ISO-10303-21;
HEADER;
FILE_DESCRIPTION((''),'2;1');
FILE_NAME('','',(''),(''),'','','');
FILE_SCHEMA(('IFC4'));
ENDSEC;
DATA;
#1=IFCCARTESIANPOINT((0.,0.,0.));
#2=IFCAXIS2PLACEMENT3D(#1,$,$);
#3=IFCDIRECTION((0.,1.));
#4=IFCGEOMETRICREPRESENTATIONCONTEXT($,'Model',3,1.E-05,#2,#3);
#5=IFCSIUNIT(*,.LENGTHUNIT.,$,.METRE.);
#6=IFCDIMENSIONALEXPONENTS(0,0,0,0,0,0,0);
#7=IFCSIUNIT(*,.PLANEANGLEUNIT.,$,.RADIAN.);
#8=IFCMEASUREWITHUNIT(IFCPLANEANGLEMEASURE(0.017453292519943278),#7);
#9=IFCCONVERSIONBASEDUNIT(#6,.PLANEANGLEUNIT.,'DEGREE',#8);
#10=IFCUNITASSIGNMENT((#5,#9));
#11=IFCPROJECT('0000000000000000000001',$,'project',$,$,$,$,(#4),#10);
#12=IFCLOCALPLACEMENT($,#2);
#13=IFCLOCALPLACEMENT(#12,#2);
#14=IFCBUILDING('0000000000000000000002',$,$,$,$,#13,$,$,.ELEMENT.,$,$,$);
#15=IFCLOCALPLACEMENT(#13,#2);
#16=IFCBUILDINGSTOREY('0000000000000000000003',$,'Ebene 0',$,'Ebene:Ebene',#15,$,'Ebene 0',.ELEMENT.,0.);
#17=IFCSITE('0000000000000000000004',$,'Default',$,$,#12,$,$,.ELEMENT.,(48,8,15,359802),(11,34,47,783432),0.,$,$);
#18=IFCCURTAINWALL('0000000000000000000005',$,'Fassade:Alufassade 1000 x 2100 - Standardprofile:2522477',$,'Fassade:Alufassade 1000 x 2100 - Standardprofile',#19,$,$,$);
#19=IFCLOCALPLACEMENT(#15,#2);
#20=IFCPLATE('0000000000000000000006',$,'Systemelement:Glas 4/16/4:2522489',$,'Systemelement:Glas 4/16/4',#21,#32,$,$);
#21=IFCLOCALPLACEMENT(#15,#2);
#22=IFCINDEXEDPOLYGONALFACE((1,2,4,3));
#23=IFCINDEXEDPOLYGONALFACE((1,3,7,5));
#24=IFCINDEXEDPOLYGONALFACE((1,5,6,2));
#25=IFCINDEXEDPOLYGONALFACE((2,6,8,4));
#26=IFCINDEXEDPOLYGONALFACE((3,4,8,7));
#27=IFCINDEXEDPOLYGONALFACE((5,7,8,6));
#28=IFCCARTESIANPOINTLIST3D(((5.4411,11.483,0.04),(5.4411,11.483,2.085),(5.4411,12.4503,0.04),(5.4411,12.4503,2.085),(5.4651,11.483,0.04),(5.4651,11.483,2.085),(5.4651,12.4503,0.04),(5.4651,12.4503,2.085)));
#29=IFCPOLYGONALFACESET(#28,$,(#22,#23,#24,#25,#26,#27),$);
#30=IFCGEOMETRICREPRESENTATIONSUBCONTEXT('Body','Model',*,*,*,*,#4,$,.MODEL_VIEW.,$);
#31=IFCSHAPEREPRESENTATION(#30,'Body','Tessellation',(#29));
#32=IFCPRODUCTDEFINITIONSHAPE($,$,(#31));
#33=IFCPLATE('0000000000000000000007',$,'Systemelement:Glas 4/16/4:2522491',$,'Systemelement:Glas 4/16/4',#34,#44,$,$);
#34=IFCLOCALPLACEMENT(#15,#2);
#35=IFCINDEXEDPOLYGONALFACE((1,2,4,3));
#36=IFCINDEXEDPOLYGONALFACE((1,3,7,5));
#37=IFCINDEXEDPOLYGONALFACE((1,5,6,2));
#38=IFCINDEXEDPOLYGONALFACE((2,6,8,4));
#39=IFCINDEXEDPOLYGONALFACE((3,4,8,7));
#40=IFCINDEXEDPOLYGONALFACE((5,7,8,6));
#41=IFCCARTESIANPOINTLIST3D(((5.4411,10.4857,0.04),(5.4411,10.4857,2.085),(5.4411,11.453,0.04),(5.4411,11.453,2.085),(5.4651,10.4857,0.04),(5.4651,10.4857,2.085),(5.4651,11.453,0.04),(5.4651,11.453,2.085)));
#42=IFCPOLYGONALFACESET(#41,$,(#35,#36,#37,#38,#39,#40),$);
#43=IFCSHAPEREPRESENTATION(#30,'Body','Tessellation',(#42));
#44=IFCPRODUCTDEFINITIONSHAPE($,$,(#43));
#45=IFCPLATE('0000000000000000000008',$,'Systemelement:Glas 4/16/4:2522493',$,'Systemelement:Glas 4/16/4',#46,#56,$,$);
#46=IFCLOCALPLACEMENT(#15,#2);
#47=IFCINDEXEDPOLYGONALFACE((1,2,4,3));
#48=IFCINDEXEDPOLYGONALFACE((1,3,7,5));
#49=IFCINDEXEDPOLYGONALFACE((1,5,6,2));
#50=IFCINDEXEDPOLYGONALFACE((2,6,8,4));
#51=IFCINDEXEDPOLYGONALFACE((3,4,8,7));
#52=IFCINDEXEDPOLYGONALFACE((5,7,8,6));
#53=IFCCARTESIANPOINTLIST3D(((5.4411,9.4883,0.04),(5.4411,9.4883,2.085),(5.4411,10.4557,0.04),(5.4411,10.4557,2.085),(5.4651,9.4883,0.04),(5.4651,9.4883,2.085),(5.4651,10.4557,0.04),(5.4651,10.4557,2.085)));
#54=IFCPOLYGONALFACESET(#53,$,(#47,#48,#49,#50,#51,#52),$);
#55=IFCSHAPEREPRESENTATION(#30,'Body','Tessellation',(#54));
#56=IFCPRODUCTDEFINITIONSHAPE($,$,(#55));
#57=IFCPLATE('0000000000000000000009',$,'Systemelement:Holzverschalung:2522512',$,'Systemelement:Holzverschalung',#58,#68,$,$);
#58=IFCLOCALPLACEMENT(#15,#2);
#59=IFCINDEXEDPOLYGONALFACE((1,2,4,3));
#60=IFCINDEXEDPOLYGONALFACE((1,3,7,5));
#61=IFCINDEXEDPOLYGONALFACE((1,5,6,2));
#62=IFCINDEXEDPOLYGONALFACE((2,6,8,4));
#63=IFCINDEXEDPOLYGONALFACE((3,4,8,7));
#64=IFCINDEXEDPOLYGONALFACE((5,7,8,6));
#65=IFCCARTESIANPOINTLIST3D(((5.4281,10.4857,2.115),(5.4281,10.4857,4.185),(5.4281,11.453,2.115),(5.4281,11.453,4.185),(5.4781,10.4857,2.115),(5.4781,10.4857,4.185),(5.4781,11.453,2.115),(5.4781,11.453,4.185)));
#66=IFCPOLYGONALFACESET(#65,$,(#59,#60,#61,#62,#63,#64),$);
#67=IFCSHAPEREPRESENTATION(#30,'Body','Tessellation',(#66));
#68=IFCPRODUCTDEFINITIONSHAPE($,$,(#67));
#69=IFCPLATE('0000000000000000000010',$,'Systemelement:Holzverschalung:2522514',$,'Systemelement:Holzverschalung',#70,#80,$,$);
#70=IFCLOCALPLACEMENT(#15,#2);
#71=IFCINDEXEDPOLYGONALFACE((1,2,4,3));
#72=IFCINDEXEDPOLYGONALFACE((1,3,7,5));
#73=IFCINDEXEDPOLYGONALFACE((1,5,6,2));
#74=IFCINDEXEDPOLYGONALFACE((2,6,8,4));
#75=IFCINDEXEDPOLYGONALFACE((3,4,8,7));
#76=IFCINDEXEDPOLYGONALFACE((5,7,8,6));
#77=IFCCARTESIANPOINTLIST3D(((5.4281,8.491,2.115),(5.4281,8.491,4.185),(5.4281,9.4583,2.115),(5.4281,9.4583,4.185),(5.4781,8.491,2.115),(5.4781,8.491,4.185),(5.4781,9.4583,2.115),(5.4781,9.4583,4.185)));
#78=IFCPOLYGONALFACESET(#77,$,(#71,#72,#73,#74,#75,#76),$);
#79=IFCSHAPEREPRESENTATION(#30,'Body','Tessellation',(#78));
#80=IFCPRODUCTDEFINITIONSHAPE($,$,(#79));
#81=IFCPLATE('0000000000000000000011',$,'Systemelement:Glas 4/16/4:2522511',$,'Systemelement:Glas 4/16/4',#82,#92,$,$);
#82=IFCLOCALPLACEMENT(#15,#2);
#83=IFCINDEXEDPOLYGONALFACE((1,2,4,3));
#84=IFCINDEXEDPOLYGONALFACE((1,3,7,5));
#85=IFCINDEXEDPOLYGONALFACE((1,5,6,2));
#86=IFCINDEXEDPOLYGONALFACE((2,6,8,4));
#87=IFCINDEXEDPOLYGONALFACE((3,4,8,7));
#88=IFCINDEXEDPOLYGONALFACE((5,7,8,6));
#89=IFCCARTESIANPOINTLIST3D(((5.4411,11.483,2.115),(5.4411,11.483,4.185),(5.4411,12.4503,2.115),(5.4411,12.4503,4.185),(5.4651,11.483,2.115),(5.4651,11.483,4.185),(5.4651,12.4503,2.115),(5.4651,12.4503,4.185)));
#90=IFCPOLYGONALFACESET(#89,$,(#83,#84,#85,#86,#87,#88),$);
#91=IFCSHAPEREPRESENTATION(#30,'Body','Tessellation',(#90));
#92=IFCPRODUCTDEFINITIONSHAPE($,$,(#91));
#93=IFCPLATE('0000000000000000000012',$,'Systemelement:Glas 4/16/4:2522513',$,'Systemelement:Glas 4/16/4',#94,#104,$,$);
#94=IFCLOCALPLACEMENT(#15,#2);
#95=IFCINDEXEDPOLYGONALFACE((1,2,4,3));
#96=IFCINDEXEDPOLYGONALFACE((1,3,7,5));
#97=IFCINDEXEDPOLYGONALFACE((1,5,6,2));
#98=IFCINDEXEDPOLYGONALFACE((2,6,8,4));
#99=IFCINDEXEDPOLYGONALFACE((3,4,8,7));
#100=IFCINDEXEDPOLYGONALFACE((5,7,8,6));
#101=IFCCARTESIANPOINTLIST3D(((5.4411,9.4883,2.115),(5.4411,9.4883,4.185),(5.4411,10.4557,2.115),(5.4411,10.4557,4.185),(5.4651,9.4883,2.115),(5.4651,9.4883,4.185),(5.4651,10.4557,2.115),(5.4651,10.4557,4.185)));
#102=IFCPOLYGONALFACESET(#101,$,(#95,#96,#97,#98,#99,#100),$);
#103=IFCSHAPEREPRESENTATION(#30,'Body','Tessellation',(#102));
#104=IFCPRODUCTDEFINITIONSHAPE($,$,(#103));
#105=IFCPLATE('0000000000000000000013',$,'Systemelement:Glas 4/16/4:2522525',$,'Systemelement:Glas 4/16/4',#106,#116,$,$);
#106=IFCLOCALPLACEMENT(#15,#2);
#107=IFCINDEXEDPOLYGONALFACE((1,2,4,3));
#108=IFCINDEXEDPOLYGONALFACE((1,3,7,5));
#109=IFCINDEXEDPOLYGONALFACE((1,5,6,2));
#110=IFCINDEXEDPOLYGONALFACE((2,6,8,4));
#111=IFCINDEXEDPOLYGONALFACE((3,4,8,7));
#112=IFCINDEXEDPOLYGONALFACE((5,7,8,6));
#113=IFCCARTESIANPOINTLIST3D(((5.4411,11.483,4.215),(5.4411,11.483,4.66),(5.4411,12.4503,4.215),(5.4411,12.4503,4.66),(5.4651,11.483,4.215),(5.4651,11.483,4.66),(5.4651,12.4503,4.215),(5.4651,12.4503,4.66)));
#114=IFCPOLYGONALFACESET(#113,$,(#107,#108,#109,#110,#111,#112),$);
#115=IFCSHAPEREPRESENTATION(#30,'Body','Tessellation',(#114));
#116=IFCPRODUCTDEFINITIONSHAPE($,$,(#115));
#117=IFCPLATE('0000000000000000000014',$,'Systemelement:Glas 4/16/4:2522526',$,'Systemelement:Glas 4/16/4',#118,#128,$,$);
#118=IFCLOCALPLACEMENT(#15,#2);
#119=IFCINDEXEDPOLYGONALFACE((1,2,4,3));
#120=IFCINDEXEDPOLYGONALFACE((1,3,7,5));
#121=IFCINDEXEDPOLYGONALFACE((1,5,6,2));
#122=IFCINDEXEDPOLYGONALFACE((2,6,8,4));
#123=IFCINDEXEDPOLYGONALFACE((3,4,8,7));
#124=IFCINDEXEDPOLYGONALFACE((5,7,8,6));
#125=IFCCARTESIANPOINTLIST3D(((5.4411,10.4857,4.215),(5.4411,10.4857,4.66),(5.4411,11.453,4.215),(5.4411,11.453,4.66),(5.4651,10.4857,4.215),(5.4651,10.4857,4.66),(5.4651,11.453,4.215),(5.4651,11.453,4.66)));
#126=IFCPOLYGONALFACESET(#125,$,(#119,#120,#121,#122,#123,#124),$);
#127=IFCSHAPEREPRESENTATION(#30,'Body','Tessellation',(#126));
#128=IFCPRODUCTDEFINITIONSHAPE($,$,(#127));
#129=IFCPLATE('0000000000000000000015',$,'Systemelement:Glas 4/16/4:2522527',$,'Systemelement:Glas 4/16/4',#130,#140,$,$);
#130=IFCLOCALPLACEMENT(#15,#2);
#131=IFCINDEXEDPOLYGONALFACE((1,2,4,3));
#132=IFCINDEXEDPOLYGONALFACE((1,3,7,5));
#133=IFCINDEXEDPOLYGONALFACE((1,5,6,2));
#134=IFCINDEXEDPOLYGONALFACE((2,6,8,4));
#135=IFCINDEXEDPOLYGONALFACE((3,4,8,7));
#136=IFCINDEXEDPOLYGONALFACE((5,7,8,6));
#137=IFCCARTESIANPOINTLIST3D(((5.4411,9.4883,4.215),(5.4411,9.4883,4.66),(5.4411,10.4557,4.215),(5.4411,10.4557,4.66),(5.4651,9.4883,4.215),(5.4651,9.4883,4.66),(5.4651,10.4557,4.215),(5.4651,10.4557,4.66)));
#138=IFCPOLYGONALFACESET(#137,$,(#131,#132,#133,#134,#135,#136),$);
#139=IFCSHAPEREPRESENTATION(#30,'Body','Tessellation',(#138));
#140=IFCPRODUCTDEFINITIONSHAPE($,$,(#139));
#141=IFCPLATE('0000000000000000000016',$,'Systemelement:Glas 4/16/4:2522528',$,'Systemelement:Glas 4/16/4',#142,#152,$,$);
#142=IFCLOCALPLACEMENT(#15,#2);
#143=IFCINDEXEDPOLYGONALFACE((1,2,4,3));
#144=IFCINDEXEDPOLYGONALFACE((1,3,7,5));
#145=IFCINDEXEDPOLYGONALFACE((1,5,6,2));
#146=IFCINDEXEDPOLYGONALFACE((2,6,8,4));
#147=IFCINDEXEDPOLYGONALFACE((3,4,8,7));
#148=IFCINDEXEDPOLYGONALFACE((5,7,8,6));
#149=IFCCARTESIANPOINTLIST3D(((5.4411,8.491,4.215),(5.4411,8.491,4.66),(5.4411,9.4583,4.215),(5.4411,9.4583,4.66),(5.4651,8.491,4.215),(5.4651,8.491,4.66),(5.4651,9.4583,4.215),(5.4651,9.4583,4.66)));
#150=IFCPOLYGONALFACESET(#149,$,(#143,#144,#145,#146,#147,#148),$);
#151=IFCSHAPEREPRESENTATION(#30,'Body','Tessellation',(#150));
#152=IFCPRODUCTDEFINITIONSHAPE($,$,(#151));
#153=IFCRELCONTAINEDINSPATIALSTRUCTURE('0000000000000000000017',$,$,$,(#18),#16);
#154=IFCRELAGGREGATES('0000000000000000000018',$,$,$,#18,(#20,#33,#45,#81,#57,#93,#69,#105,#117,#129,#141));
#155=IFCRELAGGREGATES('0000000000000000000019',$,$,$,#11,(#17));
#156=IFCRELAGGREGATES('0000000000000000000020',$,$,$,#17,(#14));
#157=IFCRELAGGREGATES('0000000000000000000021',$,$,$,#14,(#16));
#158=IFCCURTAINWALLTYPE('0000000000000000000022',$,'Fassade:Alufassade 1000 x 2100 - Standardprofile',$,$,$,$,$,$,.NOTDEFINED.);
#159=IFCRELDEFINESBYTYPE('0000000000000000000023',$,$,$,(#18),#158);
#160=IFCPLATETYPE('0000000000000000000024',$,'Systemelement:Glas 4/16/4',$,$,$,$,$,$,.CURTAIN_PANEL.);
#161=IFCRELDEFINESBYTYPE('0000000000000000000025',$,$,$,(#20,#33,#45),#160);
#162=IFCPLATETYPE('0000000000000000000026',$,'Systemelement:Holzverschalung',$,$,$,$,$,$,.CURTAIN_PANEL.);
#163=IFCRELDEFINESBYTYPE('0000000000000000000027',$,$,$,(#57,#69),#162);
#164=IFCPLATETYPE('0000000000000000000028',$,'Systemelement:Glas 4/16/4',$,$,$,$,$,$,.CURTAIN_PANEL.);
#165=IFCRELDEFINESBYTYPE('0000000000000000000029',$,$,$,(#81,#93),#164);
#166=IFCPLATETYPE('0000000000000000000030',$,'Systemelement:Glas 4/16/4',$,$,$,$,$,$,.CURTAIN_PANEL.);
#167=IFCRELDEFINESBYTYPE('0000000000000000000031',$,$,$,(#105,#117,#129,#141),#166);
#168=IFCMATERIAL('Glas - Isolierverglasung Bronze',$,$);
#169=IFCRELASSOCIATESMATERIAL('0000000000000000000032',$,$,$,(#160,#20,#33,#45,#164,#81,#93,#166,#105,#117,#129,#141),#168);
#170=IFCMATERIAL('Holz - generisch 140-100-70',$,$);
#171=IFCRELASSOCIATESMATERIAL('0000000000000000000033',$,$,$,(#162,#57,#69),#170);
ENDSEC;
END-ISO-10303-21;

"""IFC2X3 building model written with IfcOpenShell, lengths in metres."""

from ifc_helpers import new_model, entity, si_unit, converted_unit, direction, frame, origin, origin_2d_with_axis, place, context, subcontext, project, spatial, rectangle, extrude, source, transform, mapped, material, type_object, type_shapes, element, aggregate, save


model = new_model("IFC2X3")

# Units and contexts
model_context = context("Model", 3, precision=1e-05, world=origin(), true_north=direction((0.0, 1.0)))
body_context = subcontext(model_context, "Body", "Model", "MODEL_VIEW")
ifc_project = project(units=[si_unit("LENGTHUNIT", "METRE"), converted_unit("PLANEANGLEUNIT", "DEGREE", entity("IfcPlaneAngleMeasure", 0.017453292519943278), si_unit("PLANEANGLEUNIT", "RADIAN"), dimensions=[0, 0, 0, 0, 0, 0, 0])], contexts=[model_context])

# Site, building, storey
site_placement = place(None, origin())
site = spatial("IfcSite", under=ifc_project, at=site_placement, Name="Default", CompositionType="ELEMENT", RefLatitude=(48, 8, 15, 359802), RefLongitude=(11, 34, 47, 783432), RefElevation=0.0)
building_placement = place(site_placement, origin())
building = spatial("IfcBuilding", under=site, at=building_placement, CompositionType="ELEMENT")
storey_placement = place(building_placement, origin())
storey = spatial("IfcBuildingStorey", under=building, at=storey_placement, Name="Ebene 0", ObjectType="Ebene:Ebene", LongName="Ebene 0", CompositionType="ELEMENT", Elevation=0.0)

# Curtain wall, plates
curtain_wall_type = type_object("IfcCurtainWallType", Name="Fassade:Alufassade 1000 x 2100 - Standardprofile", PredefinedType="NOTDEFINED")
curtain_wall_placement = place(storey_placement, origin())
curtain_wall = element("IfcCurtainWall", 1, at=curtain_wall_placement, inside=storey, type_object=curtain_wall_type, Name="Fassade:Alufassade 1000 x 2100 - Standardprofile:2522477", ObjectType="Fassade:Alufassade 1000 x 2100 - Standardprofile")
ifc_material_1 = material(Name="Glas - Isolierverglasung Bronze")
plate_type_1 = type_object("IfcPlateType", Name="Systemelement:Glas 4/16/4", PredefinedType="CURTAIN_PANEL", material=ifc_material_1)
shared_shape_1 = source(origin(), body_context, "Body", "SweptSolid", [
    extrude(rectangle(XDim=0.024, YDim=0.9673, at=origin_2d_with_axis()), frame((0.0, 0.0, 0.0), z_axis=(0.0, 0.0, 1.0), x_axis=(0.0, 1.0, 0.0)), (0.0, 0.0, 1.0), 2.045),
])
type_shapes(plate_type_1, [shared_shape_1])
plate_1_placement = place(curtain_wall_placement, frame((5.4531, 11.9666, 0.04), z_axis=(0.0, 0.0, 1.0), x_axis=(0.0, -1.0, 0.0)))
plate_1 = element("IfcPlate", 2, at=plate_1_placement, type_object=plate_type_1, material=ifc_material_1, Name="Systemelement:Glas 4/16/4:2522489", ObjectType="Systemelement:Glas 4/16/4", context=body_context, shape_type="MappedRepresentation", body=[
    mapped(shared_shape_1, transform((0.0, 0.0, 0.0), scale=1.0)),
])
plate_2_placement = place(curtain_wall_placement, frame((5.4531, 10.9693, 0.04), z_axis=(0.0, 0.0, 1.0), x_axis=(0.0, -1.0, 0.0)))
plate_2 = element("IfcPlate", 3, at=plate_2_placement, type_object=plate_type_1, material=ifc_material_1, Name="Systemelement:Glas 4/16/4:2522491", ObjectType="Systemelement:Glas 4/16/4", context=body_context, shape_type="MappedRepresentation", body=[
    mapped(shared_shape_1, transform((0.0, 0.0, 0.0), scale=1.0)),
])
plate_3_placement = place(curtain_wall_placement, frame((5.4531, 9.972, 0.04), z_axis=(0.0, 0.0, 1.0), x_axis=(0.0, -1.0, 0.0)))
plate_3 = element("IfcPlate", 4, at=plate_3_placement, type_object=plate_type_1, material=ifc_material_1, Name="Systemelement:Glas 4/16/4:2522493", ObjectType="Systemelement:Glas 4/16/4", context=body_context, shape_type="MappedRepresentation", body=[
    mapped(shared_shape_1, transform((0.0, 0.0, 0.0), scale=1.0)),
])
ifc_material_2 = material(Name="Holz - generisch 140-100-70")
plate_type_2 = type_object("IfcPlateType", Name="Systemelement:Holzverschalung", PredefinedType="CURTAIN_PANEL", material=ifc_material_2)
shared_shape_2 = source(origin(), body_context, "Body", "SweptSolid", [
    extrude(rectangle(XDim=0.05, YDim=0.9673, at=origin_2d_with_axis()), frame((0.0, 0.0, 0.0), z_axis=(0.0, 0.0, 1.0), x_axis=(0.0, 1.0, 0.0)), (0.0, 0.0, 1.0), 2.07),
])
type_shapes(plate_type_2, [shared_shape_2])
plate_4_placement = place(curtain_wall_placement, frame((5.4531, 10.9693, 2.115), z_axis=(0.0, 0.0, 1.0), x_axis=(0.0, -1.0, 0.0)))
plate_4 = element("IfcPlate", 5, at=plate_4_placement, type_object=plate_type_2, material=ifc_material_2, Name="Systemelement:Holzverschalung:2522512", ObjectType="Systemelement:Holzverschalung", context=body_context, shape_type="MappedRepresentation", body=[
    mapped(shared_shape_2, transform((0.0, 0.0, 0.0), scale=1.0)),
])
plate_5_placement = place(curtain_wall_placement, frame((5.4531, 8.9747, 2.115), z_axis=(0.0, 0.0, 1.0), x_axis=(0.0, -1.0, 0.0)))
plate_5 = element("IfcPlate", 6, at=plate_5_placement, type_object=plate_type_2, material=ifc_material_2, Name="Systemelement:Holzverschalung:2522514", ObjectType="Systemelement:Holzverschalung", context=body_context, shape_type="MappedRepresentation", body=[
    mapped(shared_shape_2, transform((0.0, 0.0, 0.0), scale=1.0)),
])
plate_type_3 = type_object("IfcPlateType", Name="Systemelement:Glas 4/16/4", PredefinedType="CURTAIN_PANEL", material=ifc_material_1)
shared_shape_3 = source(origin(), body_context, "Body", "SweptSolid", [
    extrude(rectangle(XDim=0.024, YDim=0.9673, at=origin_2d_with_axis()), frame((0.0, 0.0, 0.0), z_axis=(0.0, 0.0, 1.0), x_axis=(0.0, 1.0, 0.0)), (0.0, 0.0, 1.0), 2.07),
])
type_shapes(plate_type_3, [shared_shape_3])
plate_6_placement = place(curtain_wall_placement, frame((5.4531, 11.9666, 2.115), z_axis=(0.0, 0.0, 1.0), x_axis=(0.0, -1.0, 0.0)))
plate_6 = element("IfcPlate", 7, at=plate_6_placement, type_object=plate_type_3, material=ifc_material_1, Name="Systemelement:Glas 4/16/4:2522511", ObjectType="Systemelement:Glas 4/16/4", context=body_context, shape_type="MappedRepresentation", body=[
    mapped(shared_shape_3, transform((0.0, 0.0, 0.0), scale=1.0)),
])
plate_7_placement = place(curtain_wall_placement, frame((5.4531, 9.972, 2.115), z_axis=(0.0, 0.0, 1.0), x_axis=(0.0, -1.0, 0.0)))
plate_7 = element("IfcPlate", 8, at=plate_7_placement, type_object=plate_type_3, material=ifc_material_1, Name="Systemelement:Glas 4/16/4:2522513", ObjectType="Systemelement:Glas 4/16/4", context=body_context, shape_type="MappedRepresentation", body=[
    mapped(shared_shape_3, transform((0.0, 0.0, 0.0), scale=1.0)),
])
plate_type_4 = type_object("IfcPlateType", Name="Systemelement:Glas 4/16/4", PredefinedType="CURTAIN_PANEL", material=ifc_material_1)
shared_shape_4 = source(origin(), body_context, "Body", "SweptSolid", [
    extrude(rectangle(XDim=0.024, YDim=0.9673, at=origin_2d_with_axis()), frame((0.0, 0.0, 0.0), z_axis=(0.0, 0.0, 1.0), x_axis=(0.0, 1.0, 0.0)), (0.0, 0.0, 1.0), 0.445),
])
type_shapes(plate_type_4, [shared_shape_4])
plate_8_placement = place(curtain_wall_placement, frame((5.4531, 11.9666, 4.215), z_axis=(0.0, 0.0, 1.0), x_axis=(0.0, -1.0, 0.0)))
plate_8 = element("IfcPlate", 9, at=plate_8_placement, type_object=plate_type_4, material=ifc_material_1, Name="Systemelement:Glas 4/16/4:2522525", ObjectType="Systemelement:Glas 4/16/4", context=body_context, shape_type="MappedRepresentation", body=[
    mapped(shared_shape_4, transform((0.0, 0.0, 0.0), scale=1.0)),
])
plate_9_placement = place(curtain_wall_placement, frame((5.4531, 10.9693, 4.215), z_axis=(0.0, 0.0, 1.0), x_axis=(0.0, -1.0, 0.0)))
plate_9 = element("IfcPlate", 10, at=plate_9_placement, type_object=plate_type_4, material=ifc_material_1, Name="Systemelement:Glas 4/16/4:2522526", ObjectType="Systemelement:Glas 4/16/4", context=body_context, shape_type="MappedRepresentation", body=[
    mapped(shared_shape_4, transform((0.0, 0.0, 0.0), scale=1.0)),
])
plate_10_placement = place(curtain_wall_placement, frame((5.4531, 9.972, 4.215), z_axis=(0.0, 0.0, 1.0), x_axis=(0.0, -1.0, 0.0)))
plate_10 = element("IfcPlate", 11, at=plate_10_placement, type_object=plate_type_4, material=ifc_material_1, Name="Systemelement:Glas 4/16/4:2522527", ObjectType="Systemelement:Glas 4/16/4", context=body_context, shape_type="MappedRepresentation", body=[
    mapped(shared_shape_4, transform((0.0, 0.0, 0.0), scale=1.0)),
])
plate_11_placement = place(curtain_wall_placement, frame((5.4531, 8.9747, 4.215), z_axis=(0.0, 0.0, 1.0), x_axis=(0.0, -1.0, 0.0)))
plate_11 = element("IfcPlate", 12, at=plate_11_placement, type_object=plate_type_4, material=ifc_material_1, Name="Systemelement:Glas 4/16/4:2522528", ObjectType="Systemelement:Glas 4/16/4", context=body_context, shape_type="MappedRepresentation", body=[
    mapped(shared_shape_4, transform((0.0, 0.0, 0.0), scale=1.0)),
])
aggregate(curtain_wall, [plate_1, plate_2, plate_3, plate_6, plate_4, plate_7, plate_5, plate_8, plate_9, plate_10, plate_11])

save(model, "model.ifc")
